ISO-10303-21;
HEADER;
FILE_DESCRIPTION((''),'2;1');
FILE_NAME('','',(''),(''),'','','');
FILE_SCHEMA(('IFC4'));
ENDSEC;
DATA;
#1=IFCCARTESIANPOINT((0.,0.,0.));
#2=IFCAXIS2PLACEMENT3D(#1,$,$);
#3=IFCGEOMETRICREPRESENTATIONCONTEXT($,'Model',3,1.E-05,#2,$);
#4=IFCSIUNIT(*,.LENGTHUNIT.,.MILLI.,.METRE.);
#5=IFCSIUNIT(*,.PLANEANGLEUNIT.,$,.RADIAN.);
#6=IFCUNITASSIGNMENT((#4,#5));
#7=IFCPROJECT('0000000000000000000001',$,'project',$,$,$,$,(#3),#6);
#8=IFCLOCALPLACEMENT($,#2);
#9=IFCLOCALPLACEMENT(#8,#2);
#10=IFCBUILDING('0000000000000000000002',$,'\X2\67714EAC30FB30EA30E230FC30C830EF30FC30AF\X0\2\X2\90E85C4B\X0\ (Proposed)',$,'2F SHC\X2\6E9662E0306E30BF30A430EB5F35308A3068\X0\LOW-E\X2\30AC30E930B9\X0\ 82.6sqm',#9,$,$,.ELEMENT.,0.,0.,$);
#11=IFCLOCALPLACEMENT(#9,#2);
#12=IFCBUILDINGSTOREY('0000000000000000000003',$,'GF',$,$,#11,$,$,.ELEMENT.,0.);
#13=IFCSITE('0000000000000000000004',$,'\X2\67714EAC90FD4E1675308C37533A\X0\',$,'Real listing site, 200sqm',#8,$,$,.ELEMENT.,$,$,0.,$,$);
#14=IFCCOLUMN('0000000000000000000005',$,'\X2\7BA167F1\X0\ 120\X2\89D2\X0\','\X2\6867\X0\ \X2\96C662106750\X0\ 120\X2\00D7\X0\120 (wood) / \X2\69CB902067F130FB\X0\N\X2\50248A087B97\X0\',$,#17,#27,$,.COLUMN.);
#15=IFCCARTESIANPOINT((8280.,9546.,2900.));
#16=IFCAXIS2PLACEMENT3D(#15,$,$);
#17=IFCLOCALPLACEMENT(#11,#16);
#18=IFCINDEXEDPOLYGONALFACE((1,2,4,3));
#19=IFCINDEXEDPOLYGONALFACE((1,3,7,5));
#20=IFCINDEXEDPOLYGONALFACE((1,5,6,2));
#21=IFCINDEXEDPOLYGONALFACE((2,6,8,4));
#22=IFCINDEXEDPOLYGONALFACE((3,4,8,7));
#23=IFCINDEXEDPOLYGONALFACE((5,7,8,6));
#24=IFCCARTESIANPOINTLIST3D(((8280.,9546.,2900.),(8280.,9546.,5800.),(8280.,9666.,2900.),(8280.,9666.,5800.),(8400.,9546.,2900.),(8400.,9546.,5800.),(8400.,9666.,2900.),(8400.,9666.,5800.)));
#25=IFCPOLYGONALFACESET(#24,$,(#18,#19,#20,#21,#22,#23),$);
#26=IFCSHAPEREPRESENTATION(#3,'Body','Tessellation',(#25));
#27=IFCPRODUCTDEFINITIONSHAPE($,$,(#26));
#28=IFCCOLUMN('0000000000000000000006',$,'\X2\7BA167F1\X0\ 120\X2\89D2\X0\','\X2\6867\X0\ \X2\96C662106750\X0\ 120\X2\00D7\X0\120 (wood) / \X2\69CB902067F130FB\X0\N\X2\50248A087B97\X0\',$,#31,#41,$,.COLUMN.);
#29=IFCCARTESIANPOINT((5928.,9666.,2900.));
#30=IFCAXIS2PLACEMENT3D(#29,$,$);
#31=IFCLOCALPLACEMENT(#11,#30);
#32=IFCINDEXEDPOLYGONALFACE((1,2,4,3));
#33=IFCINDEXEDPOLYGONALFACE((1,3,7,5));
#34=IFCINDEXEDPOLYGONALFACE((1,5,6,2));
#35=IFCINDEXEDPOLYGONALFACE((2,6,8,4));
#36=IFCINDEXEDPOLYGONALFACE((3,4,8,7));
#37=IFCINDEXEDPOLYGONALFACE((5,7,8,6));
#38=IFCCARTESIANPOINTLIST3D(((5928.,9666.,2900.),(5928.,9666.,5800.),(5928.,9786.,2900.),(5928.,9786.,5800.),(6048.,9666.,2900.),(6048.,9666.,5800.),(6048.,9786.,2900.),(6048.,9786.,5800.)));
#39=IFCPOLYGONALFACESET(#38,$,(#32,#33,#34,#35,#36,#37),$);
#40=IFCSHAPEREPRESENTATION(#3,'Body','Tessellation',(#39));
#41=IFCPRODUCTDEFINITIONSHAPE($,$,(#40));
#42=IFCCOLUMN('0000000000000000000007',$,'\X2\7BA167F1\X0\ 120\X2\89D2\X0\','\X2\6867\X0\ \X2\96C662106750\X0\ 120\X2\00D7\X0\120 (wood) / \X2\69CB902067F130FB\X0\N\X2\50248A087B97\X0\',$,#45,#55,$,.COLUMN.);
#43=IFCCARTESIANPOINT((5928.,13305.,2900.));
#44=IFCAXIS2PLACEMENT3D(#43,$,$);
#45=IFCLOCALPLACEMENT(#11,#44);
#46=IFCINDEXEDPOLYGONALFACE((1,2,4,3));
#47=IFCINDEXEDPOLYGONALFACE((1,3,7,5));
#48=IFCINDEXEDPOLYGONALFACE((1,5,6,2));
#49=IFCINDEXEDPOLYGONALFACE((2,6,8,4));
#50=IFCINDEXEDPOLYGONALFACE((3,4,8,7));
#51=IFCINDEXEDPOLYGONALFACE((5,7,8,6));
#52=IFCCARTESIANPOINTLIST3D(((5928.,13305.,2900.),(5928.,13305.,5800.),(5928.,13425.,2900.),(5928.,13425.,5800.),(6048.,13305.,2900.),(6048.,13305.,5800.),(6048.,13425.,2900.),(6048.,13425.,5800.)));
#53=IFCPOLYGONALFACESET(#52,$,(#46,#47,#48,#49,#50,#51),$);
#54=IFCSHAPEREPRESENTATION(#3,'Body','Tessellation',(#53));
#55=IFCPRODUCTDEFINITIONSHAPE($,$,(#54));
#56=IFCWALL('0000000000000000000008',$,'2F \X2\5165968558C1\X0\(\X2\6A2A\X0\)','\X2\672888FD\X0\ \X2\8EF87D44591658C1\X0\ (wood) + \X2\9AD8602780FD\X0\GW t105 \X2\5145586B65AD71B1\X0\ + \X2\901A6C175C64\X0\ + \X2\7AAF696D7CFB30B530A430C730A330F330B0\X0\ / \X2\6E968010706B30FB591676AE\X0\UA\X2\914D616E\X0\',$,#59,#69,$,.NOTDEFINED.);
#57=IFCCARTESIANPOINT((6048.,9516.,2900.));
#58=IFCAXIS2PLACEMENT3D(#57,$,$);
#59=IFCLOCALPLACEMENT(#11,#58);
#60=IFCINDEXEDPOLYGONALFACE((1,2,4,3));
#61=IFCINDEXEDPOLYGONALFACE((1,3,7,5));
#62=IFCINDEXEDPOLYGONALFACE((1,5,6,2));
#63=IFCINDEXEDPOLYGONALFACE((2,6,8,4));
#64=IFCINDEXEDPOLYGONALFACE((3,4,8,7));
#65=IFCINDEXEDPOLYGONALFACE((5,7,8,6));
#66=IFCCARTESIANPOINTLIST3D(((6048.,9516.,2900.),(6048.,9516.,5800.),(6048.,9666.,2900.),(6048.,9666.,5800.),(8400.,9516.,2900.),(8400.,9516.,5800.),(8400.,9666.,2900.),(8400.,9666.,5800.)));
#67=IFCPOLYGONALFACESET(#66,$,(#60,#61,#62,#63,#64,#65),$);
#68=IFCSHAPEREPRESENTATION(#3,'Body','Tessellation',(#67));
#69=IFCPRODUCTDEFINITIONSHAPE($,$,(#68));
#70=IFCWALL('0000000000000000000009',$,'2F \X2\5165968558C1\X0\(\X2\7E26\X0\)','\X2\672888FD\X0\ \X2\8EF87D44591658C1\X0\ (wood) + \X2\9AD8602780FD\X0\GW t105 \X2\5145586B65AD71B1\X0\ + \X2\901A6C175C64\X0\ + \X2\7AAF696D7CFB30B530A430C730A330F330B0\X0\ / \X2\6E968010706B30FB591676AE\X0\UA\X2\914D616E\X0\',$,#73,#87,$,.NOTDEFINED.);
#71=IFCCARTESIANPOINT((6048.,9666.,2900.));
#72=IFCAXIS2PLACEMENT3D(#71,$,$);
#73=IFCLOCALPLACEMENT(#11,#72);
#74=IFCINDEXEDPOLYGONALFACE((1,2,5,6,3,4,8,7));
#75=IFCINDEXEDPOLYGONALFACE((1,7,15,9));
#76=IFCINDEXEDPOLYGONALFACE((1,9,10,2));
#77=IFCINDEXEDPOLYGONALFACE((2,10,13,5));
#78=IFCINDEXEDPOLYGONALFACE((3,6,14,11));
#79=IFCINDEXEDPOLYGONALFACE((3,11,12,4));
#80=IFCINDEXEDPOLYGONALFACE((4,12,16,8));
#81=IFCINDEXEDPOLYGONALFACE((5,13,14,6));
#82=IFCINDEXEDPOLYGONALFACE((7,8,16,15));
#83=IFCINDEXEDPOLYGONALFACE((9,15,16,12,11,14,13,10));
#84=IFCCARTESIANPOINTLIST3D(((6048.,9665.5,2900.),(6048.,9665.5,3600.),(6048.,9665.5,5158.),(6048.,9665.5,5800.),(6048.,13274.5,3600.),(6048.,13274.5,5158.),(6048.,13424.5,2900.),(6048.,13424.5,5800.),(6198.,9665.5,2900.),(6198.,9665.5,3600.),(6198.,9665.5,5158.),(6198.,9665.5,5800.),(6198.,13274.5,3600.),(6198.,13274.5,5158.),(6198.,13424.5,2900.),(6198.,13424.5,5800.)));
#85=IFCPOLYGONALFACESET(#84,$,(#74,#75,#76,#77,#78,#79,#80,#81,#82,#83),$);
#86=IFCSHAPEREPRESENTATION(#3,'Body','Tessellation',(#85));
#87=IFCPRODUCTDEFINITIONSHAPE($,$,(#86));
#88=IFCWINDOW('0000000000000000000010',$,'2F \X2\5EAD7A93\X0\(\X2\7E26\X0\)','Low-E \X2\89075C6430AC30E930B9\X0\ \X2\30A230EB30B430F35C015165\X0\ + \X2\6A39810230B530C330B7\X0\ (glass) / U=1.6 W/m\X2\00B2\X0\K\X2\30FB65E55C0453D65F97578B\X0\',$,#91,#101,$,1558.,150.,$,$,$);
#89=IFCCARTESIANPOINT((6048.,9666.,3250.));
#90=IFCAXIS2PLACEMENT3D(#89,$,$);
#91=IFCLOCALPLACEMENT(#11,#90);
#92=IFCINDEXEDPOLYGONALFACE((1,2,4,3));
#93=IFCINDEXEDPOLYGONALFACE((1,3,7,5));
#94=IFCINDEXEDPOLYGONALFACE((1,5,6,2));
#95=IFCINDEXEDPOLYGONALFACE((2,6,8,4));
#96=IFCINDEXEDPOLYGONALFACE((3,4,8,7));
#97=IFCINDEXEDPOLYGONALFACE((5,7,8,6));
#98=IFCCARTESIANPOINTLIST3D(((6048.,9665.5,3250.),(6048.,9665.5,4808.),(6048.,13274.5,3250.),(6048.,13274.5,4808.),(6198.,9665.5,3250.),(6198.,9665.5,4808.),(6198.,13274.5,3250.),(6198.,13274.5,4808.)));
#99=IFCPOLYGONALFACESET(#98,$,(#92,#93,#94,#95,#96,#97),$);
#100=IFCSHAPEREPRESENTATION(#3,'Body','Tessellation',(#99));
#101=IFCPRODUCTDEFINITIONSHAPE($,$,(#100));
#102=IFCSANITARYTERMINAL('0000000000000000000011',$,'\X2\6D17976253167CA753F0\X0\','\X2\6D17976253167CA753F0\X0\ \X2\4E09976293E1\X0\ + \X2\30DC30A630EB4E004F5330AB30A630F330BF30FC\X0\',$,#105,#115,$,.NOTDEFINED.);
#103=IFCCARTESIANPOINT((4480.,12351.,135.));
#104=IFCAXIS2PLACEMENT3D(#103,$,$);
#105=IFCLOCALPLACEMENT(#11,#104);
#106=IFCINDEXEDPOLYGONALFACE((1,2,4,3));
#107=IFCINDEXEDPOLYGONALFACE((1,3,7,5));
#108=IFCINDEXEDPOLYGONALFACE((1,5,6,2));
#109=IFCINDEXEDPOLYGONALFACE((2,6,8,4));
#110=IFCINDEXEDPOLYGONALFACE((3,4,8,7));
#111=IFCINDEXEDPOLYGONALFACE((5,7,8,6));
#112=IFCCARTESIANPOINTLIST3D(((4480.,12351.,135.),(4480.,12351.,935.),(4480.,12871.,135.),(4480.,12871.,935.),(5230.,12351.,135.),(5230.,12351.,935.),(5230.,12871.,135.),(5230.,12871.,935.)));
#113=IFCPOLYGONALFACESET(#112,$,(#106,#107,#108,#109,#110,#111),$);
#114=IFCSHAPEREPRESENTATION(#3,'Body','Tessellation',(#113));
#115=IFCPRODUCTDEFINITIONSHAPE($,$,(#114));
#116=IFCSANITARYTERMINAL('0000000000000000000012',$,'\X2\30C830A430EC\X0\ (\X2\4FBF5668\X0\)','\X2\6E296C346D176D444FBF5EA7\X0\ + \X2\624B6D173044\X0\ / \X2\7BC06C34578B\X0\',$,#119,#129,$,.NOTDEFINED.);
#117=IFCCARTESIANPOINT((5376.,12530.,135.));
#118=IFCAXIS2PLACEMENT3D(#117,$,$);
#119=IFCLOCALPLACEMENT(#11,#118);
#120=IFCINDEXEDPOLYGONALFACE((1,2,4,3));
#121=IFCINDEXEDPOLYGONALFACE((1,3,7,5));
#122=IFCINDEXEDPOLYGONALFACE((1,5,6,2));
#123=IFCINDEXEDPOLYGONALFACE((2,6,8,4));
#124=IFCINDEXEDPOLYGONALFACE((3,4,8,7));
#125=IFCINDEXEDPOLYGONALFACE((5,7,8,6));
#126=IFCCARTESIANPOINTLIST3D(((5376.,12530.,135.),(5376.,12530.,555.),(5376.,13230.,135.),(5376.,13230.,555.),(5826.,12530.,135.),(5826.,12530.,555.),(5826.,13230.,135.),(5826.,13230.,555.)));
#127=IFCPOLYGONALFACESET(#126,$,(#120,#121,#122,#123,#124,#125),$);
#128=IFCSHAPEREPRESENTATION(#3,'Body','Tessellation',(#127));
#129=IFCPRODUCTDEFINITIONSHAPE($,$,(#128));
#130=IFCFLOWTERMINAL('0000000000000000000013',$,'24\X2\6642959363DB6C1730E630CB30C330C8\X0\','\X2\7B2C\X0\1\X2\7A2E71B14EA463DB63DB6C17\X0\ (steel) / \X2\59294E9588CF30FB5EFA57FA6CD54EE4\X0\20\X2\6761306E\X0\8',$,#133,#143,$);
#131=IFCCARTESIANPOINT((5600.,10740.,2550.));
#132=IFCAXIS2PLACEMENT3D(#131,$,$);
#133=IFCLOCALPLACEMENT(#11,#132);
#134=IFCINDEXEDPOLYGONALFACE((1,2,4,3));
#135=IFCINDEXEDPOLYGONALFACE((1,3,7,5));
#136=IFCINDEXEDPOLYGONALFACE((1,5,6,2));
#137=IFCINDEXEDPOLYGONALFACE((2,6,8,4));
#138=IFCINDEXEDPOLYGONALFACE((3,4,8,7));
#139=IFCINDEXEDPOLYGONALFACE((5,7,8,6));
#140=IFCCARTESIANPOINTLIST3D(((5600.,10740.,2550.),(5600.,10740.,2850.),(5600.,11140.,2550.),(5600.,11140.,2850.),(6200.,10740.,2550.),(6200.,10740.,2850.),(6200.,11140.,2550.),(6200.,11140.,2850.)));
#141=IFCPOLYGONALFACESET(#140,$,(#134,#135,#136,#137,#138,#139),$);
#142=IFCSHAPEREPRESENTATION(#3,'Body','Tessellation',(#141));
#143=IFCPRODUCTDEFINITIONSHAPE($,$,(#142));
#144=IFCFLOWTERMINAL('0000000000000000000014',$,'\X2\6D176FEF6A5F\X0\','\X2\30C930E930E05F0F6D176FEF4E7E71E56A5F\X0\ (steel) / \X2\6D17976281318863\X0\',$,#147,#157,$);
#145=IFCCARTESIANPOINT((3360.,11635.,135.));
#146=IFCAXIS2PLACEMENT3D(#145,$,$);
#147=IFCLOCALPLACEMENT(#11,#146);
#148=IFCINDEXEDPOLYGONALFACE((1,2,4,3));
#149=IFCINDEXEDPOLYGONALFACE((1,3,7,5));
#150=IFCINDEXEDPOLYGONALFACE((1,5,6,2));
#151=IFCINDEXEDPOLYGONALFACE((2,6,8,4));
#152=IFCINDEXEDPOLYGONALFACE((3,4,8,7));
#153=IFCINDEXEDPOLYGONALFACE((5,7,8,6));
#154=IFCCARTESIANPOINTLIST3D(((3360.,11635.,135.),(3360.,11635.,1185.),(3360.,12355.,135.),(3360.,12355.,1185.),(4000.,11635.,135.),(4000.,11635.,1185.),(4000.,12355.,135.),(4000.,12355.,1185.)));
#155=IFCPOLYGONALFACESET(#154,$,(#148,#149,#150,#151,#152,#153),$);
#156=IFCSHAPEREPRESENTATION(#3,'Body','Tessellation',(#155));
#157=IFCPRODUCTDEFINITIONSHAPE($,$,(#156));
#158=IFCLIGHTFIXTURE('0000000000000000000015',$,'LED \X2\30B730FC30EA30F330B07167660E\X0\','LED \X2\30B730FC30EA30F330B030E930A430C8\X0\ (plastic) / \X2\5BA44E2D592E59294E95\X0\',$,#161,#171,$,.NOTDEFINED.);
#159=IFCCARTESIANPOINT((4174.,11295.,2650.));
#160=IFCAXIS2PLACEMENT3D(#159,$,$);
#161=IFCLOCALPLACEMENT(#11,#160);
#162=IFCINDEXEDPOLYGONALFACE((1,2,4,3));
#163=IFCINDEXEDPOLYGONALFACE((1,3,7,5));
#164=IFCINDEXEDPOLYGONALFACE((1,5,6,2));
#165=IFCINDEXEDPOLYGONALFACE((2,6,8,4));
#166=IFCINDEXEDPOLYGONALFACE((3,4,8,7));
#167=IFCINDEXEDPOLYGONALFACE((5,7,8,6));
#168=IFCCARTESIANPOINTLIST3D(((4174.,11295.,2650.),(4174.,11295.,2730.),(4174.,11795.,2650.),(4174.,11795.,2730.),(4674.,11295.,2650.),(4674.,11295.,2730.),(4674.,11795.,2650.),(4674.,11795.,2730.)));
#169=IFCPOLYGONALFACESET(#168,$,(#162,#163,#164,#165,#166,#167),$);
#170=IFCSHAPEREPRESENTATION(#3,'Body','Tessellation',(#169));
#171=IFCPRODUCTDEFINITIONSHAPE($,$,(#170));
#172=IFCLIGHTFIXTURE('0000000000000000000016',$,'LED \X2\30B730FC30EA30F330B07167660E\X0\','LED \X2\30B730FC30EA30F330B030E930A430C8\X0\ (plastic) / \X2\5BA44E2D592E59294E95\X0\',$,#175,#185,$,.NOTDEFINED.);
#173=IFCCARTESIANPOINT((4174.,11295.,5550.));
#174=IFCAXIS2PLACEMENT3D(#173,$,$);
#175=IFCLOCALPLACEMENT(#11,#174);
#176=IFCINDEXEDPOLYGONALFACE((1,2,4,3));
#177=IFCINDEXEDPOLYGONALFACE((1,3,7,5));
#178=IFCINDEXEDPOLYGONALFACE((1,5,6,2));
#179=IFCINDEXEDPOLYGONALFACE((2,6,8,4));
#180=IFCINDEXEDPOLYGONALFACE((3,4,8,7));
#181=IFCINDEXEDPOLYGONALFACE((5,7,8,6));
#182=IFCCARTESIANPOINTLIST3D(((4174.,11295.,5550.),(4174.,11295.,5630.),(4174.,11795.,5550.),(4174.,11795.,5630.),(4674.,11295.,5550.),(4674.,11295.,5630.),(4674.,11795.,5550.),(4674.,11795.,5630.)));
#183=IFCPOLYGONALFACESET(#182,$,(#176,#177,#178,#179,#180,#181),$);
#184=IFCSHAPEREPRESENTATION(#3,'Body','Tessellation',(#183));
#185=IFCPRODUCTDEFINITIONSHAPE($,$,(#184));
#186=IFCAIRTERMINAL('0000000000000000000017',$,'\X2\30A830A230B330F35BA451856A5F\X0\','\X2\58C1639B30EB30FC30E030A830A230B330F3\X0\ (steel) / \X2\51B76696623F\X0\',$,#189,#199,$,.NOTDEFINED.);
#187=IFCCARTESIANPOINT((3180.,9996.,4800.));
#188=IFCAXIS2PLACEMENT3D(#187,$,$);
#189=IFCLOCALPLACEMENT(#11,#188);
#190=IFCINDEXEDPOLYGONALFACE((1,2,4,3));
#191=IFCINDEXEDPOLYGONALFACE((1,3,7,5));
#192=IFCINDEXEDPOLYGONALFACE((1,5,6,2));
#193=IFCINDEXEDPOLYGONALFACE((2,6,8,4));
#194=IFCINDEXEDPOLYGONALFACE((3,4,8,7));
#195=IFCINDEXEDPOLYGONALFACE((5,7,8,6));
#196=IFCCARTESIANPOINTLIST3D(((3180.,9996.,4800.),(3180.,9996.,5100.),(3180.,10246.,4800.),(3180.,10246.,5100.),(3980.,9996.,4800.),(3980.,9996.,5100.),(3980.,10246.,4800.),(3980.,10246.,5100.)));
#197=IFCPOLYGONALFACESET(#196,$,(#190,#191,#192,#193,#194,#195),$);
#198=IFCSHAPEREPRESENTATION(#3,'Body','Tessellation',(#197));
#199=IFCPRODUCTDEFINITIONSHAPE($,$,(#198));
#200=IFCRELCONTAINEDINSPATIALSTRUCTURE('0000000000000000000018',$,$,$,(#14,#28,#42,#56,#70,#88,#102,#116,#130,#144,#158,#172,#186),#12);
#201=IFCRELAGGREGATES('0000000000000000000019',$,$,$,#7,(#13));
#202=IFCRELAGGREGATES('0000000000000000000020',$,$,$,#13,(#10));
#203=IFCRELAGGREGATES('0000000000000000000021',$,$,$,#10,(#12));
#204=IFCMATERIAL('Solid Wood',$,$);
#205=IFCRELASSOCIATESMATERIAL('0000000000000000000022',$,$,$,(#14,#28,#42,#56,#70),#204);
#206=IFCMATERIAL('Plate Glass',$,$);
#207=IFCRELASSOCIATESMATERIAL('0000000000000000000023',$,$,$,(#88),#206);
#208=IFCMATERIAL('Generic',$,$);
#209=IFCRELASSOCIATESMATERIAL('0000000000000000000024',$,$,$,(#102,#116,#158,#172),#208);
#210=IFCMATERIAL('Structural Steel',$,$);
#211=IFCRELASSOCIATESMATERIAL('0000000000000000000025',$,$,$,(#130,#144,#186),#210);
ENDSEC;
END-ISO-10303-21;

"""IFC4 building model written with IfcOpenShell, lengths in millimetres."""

from ifc_helpers import new_model, si_unit, frame, frame_2d, origin, place, context, project, spatial, rectangle, extrude, material, element, fill, save


model = new_model("IFC4")

# Units and contexts
model_context = context("Model", 3, precision=1e-05, world=origin())
ifc_project = project(units=[si_unit("LENGTHUNIT", "METRE", prefix="MILLI"), si_unit("PLANEANGLEUNIT", "RADIAN")], contexts=[model_context])

# Site, building, storey
site_placement = place(None, origin())
site = spatial("IfcSite", under=ifc_project, at=site_placement, Name="東京都世田谷区", ObjectType="Real listing site, 200sqm", CompositionType="ELEMENT", RefElevation=0.0)
building_placement = place(site_placement, origin())
building = spatial("IfcBuilding", under=site, at=building_placement, Name="東京・リモートワーク2部屋 (Proposed)", ObjectType="2F SHC準拠のタイル張りとLOW-Eガラス 82.6sqm", CompositionType="ELEMENT", ElevationOfRefHeight=0.0, ElevationOfTerrain=0.0)
storey_placement = place(building_placement, origin())
storey = spatial("IfcBuildingStorey", under=building, at=storey_placement, Name="GF", CompositionType="ELEMENT", Elevation=0.0)

# Columns
ifc_material_1 = material(Name="Solid Wood")
column_1_placement = place(storey_placement, frame((8280.0, 9546.0, 2900.0)))
element("IfcColumn", 1, at=column_1_placement, inside=storey, material=ifc_material_1, Name="管柱 120角", Description="桧 集成材 120×120 (wood) / 構造柱・N値計算", PredefinedType="COLUMN", context=model_context, shape_type="SweptSolid", body=[
    extrude(rectangle(XDim=120.0, YDim=120.0, at=frame_2d((60.0, 60.0))), frame((8280.0, 9546.0, 2900.0)), (0.0, 0.0, 1.0), 2900.0),
])
column_2_placement = place(storey_placement, frame((5928.0, 9666.0, 2900.0)))
element("IfcColumn", 2, at=column_2_placement, inside=storey, material=ifc_material_1, Name="管柱 120角", Description="桧 集成材 120×120 (wood) / 構造柱・N値計算", PredefinedType="COLUMN", context=model_context, shape_type="SweptSolid", body=[
    extrude(rectangle(XDim=120.0, YDim=120.0, at=frame_2d((60.0, 60.0))), frame((5928.0, 9666.0, 2900.0)), (0.0, 0.0, 1.0), 2900.0),
])
column_3_placement = place(storey_placement, frame((5928.0, 13305.0, 2900.0)))
element("IfcColumn", 3, at=column_3_placement, inside=storey, material=ifc_material_1, Name="管柱 120角", Description="桧 集成材 120×120 (wood) / 構造柱・N値計算", PredefinedType="COLUMN", context=model_context, shape_type="SweptSolid", body=[
    extrude(rectangle(XDim=120.0, YDim=120.0, at=frame_2d((60.0, 60.0))), frame((5928.0, 13305.0, 2900.0)), (0.0, 0.0, 1.0), 2900.0),
])

# Wall
wall_1_placement = place(storey_placement, frame((6048.0, 9516.0, 2900.0)))
element("IfcWall", 4, at=wall_1_placement, inside=storey, material=ifc_material_1, Name="2F 入隅壁(横)", Description="木製 軸組外壁 (wood) + 高性能GW t105 充填断熱 + 通気層 + 窯業系サイディング / 準耐火・外皮UA配慮", PredefinedType="NOTDEFINED", context=model_context, shape_type="SweptSolid", body=[
    extrude(rectangle(XDim=2352.0, YDim=150.0, at=frame_2d((1176.0, 75.0))), frame((6048.0, 9516.0, 2900.0)), (0.0, 0.0, 1.0), 2900.0),
])

# Wall, opening, window
wall_2_placement = place(storey_placement, frame((6048.0, 9666.0, 2900.0)))
wall_2 = element("IfcWall", 5, at=wall_2_placement, inside=storey, material=ifc_material_1, Name="2F 入隅壁(縦)", Description="木製 軸組外壁 (wood) + 高性能GW t105 充填断熱 + 通気層 + 窯業系サイディング / 準耐火・外皮UA配慮", PredefinedType="NOTDEFINED", context=model_context, shape_type="SweptSolid", body=[
    extrude(rectangle(XDim=150.0, YDim=3759.0, at=frame_2d((75.0, 1879.0))), frame((6048.0, 9666.0, 2900.0)), (0.0, 0.0, 1.0), 2900.0),
])
opening_placement = place(storey_placement, frame((6048.0, 9666.0, 3250.0)))
opening = element("IfcOpeningElement", 6, at=opening_placement, cuts=wall_2, PredefinedType="NOTDEFINED", context=model_context, shape_type="SweptSolid", body=[
    extrude(rectangle(XDim=150.0, YDim=3609.0, at=frame_2d((75.0, 1804.0))), frame((6048.0, 9666.0, 3250.0)), (0.0, 0.0, 1.0), 1558.0),
])
ifc_material_2 = material(Name="Plate Glass")
window_placement = place(storey_placement, frame((6048.0, 9666.0, 3250.0)))
window = element("IfcWindow", 7, at=window_placement, inside=storey, material=ifc_material_2, Name="2F 庭窓(縦)", Description="Low-E 複層ガラス アルゴン封入 + 樹脂サッシ (glass) / U=1.6 W/m²K・日射取得型", OverallHeight=1558.0, OverallWidth=150.0, context=model_context, shape_type="SweptSolid", body=[
    extrude(rectangle(XDim=150.0, YDim=3609.0, at=frame_2d((75.0, 1804.0))), frame((6048.0, 9666.0, 3250.0)), (0.0, 0.0, 1.0), 1558.0),
])
fill(opening, window)

# Sanitary terminals
ifc_material_3 = material(Name="Generic")
sanitary_terminal_1_placement = place(storey_placement, frame((4480.0, 12351.0, 135.0)))
element("IfcSanitaryTerminal", 8, at=sanitary_terminal_1_placement, inside=storey, material=ifc_material_3, Name="洗面化粧台", Description="洗面化粧台 三面鏡 + ボウル一体カウンター", PredefinedType="NOTDEFINED", context=model_context, shape_type="SweptSolid", body=[
    extrude(rectangle(XDim=750.0, YDim=520.0, at=frame_2d((375.0, 260.0))), frame((4480.0, 12351.0, 135.0)), (0.0, 0.0, 1.0), 800.0),
])
sanitary_terminal_2_placement = place(storey_placement, frame((5376.0, 12530.0, 135.0)))
element("IfcSanitaryTerminal", 9, at=sanitary_terminal_2_placement, inside=storey, material=ifc_material_3, Name="トイレ (便器)", Description="温水洗浄便座 + 手洗い / 節水型", PredefinedType="NOTDEFINED", context=model_context, shape_type="SweptSolid", body=[
    extrude(rectangle(XDim=450.0, YDim=700.0, at=frame_2d((225.0, 350.0))), frame((5376.0, 12530.0, 135.0)), (0.0, 0.0, 1.0), 420.0),
])

# Flow terminals
ifc_material_4 = material(Name="Structural Steel")
flow_terminal_1_placement = place(storey_placement, frame((5600.0, 10740.0, 2550.0)))
element("IfcFlowTerminal", 10, at=flow_terminal_1_placement, inside=storey, material=ifc_material_4, Name="24時間換気ユニット", Description="第1種熱交換換気 (steel) / 天井裏・建基法令20条の8", context=model_context, shape_type="SweptSolid", body=[
    extrude(rectangle(XDim=600.0, YDim=400.0, at=frame_2d((300.0, 200.0))), frame((5600.0, 10740.0, 2550.0)), (0.0, 0.0, 1.0), 300.0),
])
flow_terminal_2_placement = place(storey_placement, frame((3360.0, 11635.0, 135.0)))
element("IfcFlowTerminal", 11, at=flow_terminal_2_placement, inside=storey, material=ifc_material_4, Name="洗濯機", Description="ドラム式洗濯乾燥機 (steel) / 洗面脱衣", context=model_context, shape_type="SweptSolid", body=[
    extrude(rectangle(XDim=640.0, YDim=720.0, at=frame_2d((320.0, 360.0))), frame((3360.0, 11635.0, 135.0)), (0.0, 0.0, 1.0), 1050.0),
])

# Light fixtures
light_fixture_1_placement = place(storey_placement, frame((4174.0, 11295.0, 2650.0)))
element("IfcLightFixture", 12, at=light_fixture_1_placement, inside=storey, material=ifc_material_3, Name="LED シーリング照明", Description="LED シーリングライト (plastic) / 室中央天井", PredefinedType="NOTDEFINED", context=model_context, shape_type="SweptSolid", body=[
    extrude(rectangle(XDim=500.0, YDim=500.0, at=frame_2d((250.0, 250.0))), frame((4174.0, 11295.0, 2650.0)), (0.0, 0.0, 1.0), 80.0),
])
light_fixture_2_placement = place(storey_placement, frame((4174.0, 11295.0, 5550.0)))
element("IfcLightFixture", 13, at=light_fixture_2_placement, inside=storey, material=ifc_material_3, Name="LED シーリング照明", Description="LED シーリングライト (plastic) / 室中央天井", PredefinedType="NOTDEFINED", context=model_context, shape_type="SweptSolid", body=[
    extrude(rectangle(XDim=500.0, YDim=500.0, at=frame_2d((250.0, 250.0))), frame((4174.0, 11295.0, 5550.0)), (0.0, 0.0, 1.0), 80.0),
])

# Air terminal
air_terminal_placement = place(storey_placement, frame((3180.0, 9996.0, 4800.0)))
element("IfcAirTerminal", 14, at=air_terminal_placement, inside=storey, material=ifc_material_4, Name="エアコン室内機", Description="壁掛ルームエアコン (steel) / 冷暖房", PredefinedType="NOTDEFINED", context=model_context, shape_type="SweptSolid", body=[
    extrude(rectangle(XDim=800.0, YDim=250.0, at=frame_2d((400.0, 125.0))), frame((3180.0, 9996.0, 4800.0)), (0.0, 0.0, 1.0), 300.0),
])

save(model, "model.ifc")
